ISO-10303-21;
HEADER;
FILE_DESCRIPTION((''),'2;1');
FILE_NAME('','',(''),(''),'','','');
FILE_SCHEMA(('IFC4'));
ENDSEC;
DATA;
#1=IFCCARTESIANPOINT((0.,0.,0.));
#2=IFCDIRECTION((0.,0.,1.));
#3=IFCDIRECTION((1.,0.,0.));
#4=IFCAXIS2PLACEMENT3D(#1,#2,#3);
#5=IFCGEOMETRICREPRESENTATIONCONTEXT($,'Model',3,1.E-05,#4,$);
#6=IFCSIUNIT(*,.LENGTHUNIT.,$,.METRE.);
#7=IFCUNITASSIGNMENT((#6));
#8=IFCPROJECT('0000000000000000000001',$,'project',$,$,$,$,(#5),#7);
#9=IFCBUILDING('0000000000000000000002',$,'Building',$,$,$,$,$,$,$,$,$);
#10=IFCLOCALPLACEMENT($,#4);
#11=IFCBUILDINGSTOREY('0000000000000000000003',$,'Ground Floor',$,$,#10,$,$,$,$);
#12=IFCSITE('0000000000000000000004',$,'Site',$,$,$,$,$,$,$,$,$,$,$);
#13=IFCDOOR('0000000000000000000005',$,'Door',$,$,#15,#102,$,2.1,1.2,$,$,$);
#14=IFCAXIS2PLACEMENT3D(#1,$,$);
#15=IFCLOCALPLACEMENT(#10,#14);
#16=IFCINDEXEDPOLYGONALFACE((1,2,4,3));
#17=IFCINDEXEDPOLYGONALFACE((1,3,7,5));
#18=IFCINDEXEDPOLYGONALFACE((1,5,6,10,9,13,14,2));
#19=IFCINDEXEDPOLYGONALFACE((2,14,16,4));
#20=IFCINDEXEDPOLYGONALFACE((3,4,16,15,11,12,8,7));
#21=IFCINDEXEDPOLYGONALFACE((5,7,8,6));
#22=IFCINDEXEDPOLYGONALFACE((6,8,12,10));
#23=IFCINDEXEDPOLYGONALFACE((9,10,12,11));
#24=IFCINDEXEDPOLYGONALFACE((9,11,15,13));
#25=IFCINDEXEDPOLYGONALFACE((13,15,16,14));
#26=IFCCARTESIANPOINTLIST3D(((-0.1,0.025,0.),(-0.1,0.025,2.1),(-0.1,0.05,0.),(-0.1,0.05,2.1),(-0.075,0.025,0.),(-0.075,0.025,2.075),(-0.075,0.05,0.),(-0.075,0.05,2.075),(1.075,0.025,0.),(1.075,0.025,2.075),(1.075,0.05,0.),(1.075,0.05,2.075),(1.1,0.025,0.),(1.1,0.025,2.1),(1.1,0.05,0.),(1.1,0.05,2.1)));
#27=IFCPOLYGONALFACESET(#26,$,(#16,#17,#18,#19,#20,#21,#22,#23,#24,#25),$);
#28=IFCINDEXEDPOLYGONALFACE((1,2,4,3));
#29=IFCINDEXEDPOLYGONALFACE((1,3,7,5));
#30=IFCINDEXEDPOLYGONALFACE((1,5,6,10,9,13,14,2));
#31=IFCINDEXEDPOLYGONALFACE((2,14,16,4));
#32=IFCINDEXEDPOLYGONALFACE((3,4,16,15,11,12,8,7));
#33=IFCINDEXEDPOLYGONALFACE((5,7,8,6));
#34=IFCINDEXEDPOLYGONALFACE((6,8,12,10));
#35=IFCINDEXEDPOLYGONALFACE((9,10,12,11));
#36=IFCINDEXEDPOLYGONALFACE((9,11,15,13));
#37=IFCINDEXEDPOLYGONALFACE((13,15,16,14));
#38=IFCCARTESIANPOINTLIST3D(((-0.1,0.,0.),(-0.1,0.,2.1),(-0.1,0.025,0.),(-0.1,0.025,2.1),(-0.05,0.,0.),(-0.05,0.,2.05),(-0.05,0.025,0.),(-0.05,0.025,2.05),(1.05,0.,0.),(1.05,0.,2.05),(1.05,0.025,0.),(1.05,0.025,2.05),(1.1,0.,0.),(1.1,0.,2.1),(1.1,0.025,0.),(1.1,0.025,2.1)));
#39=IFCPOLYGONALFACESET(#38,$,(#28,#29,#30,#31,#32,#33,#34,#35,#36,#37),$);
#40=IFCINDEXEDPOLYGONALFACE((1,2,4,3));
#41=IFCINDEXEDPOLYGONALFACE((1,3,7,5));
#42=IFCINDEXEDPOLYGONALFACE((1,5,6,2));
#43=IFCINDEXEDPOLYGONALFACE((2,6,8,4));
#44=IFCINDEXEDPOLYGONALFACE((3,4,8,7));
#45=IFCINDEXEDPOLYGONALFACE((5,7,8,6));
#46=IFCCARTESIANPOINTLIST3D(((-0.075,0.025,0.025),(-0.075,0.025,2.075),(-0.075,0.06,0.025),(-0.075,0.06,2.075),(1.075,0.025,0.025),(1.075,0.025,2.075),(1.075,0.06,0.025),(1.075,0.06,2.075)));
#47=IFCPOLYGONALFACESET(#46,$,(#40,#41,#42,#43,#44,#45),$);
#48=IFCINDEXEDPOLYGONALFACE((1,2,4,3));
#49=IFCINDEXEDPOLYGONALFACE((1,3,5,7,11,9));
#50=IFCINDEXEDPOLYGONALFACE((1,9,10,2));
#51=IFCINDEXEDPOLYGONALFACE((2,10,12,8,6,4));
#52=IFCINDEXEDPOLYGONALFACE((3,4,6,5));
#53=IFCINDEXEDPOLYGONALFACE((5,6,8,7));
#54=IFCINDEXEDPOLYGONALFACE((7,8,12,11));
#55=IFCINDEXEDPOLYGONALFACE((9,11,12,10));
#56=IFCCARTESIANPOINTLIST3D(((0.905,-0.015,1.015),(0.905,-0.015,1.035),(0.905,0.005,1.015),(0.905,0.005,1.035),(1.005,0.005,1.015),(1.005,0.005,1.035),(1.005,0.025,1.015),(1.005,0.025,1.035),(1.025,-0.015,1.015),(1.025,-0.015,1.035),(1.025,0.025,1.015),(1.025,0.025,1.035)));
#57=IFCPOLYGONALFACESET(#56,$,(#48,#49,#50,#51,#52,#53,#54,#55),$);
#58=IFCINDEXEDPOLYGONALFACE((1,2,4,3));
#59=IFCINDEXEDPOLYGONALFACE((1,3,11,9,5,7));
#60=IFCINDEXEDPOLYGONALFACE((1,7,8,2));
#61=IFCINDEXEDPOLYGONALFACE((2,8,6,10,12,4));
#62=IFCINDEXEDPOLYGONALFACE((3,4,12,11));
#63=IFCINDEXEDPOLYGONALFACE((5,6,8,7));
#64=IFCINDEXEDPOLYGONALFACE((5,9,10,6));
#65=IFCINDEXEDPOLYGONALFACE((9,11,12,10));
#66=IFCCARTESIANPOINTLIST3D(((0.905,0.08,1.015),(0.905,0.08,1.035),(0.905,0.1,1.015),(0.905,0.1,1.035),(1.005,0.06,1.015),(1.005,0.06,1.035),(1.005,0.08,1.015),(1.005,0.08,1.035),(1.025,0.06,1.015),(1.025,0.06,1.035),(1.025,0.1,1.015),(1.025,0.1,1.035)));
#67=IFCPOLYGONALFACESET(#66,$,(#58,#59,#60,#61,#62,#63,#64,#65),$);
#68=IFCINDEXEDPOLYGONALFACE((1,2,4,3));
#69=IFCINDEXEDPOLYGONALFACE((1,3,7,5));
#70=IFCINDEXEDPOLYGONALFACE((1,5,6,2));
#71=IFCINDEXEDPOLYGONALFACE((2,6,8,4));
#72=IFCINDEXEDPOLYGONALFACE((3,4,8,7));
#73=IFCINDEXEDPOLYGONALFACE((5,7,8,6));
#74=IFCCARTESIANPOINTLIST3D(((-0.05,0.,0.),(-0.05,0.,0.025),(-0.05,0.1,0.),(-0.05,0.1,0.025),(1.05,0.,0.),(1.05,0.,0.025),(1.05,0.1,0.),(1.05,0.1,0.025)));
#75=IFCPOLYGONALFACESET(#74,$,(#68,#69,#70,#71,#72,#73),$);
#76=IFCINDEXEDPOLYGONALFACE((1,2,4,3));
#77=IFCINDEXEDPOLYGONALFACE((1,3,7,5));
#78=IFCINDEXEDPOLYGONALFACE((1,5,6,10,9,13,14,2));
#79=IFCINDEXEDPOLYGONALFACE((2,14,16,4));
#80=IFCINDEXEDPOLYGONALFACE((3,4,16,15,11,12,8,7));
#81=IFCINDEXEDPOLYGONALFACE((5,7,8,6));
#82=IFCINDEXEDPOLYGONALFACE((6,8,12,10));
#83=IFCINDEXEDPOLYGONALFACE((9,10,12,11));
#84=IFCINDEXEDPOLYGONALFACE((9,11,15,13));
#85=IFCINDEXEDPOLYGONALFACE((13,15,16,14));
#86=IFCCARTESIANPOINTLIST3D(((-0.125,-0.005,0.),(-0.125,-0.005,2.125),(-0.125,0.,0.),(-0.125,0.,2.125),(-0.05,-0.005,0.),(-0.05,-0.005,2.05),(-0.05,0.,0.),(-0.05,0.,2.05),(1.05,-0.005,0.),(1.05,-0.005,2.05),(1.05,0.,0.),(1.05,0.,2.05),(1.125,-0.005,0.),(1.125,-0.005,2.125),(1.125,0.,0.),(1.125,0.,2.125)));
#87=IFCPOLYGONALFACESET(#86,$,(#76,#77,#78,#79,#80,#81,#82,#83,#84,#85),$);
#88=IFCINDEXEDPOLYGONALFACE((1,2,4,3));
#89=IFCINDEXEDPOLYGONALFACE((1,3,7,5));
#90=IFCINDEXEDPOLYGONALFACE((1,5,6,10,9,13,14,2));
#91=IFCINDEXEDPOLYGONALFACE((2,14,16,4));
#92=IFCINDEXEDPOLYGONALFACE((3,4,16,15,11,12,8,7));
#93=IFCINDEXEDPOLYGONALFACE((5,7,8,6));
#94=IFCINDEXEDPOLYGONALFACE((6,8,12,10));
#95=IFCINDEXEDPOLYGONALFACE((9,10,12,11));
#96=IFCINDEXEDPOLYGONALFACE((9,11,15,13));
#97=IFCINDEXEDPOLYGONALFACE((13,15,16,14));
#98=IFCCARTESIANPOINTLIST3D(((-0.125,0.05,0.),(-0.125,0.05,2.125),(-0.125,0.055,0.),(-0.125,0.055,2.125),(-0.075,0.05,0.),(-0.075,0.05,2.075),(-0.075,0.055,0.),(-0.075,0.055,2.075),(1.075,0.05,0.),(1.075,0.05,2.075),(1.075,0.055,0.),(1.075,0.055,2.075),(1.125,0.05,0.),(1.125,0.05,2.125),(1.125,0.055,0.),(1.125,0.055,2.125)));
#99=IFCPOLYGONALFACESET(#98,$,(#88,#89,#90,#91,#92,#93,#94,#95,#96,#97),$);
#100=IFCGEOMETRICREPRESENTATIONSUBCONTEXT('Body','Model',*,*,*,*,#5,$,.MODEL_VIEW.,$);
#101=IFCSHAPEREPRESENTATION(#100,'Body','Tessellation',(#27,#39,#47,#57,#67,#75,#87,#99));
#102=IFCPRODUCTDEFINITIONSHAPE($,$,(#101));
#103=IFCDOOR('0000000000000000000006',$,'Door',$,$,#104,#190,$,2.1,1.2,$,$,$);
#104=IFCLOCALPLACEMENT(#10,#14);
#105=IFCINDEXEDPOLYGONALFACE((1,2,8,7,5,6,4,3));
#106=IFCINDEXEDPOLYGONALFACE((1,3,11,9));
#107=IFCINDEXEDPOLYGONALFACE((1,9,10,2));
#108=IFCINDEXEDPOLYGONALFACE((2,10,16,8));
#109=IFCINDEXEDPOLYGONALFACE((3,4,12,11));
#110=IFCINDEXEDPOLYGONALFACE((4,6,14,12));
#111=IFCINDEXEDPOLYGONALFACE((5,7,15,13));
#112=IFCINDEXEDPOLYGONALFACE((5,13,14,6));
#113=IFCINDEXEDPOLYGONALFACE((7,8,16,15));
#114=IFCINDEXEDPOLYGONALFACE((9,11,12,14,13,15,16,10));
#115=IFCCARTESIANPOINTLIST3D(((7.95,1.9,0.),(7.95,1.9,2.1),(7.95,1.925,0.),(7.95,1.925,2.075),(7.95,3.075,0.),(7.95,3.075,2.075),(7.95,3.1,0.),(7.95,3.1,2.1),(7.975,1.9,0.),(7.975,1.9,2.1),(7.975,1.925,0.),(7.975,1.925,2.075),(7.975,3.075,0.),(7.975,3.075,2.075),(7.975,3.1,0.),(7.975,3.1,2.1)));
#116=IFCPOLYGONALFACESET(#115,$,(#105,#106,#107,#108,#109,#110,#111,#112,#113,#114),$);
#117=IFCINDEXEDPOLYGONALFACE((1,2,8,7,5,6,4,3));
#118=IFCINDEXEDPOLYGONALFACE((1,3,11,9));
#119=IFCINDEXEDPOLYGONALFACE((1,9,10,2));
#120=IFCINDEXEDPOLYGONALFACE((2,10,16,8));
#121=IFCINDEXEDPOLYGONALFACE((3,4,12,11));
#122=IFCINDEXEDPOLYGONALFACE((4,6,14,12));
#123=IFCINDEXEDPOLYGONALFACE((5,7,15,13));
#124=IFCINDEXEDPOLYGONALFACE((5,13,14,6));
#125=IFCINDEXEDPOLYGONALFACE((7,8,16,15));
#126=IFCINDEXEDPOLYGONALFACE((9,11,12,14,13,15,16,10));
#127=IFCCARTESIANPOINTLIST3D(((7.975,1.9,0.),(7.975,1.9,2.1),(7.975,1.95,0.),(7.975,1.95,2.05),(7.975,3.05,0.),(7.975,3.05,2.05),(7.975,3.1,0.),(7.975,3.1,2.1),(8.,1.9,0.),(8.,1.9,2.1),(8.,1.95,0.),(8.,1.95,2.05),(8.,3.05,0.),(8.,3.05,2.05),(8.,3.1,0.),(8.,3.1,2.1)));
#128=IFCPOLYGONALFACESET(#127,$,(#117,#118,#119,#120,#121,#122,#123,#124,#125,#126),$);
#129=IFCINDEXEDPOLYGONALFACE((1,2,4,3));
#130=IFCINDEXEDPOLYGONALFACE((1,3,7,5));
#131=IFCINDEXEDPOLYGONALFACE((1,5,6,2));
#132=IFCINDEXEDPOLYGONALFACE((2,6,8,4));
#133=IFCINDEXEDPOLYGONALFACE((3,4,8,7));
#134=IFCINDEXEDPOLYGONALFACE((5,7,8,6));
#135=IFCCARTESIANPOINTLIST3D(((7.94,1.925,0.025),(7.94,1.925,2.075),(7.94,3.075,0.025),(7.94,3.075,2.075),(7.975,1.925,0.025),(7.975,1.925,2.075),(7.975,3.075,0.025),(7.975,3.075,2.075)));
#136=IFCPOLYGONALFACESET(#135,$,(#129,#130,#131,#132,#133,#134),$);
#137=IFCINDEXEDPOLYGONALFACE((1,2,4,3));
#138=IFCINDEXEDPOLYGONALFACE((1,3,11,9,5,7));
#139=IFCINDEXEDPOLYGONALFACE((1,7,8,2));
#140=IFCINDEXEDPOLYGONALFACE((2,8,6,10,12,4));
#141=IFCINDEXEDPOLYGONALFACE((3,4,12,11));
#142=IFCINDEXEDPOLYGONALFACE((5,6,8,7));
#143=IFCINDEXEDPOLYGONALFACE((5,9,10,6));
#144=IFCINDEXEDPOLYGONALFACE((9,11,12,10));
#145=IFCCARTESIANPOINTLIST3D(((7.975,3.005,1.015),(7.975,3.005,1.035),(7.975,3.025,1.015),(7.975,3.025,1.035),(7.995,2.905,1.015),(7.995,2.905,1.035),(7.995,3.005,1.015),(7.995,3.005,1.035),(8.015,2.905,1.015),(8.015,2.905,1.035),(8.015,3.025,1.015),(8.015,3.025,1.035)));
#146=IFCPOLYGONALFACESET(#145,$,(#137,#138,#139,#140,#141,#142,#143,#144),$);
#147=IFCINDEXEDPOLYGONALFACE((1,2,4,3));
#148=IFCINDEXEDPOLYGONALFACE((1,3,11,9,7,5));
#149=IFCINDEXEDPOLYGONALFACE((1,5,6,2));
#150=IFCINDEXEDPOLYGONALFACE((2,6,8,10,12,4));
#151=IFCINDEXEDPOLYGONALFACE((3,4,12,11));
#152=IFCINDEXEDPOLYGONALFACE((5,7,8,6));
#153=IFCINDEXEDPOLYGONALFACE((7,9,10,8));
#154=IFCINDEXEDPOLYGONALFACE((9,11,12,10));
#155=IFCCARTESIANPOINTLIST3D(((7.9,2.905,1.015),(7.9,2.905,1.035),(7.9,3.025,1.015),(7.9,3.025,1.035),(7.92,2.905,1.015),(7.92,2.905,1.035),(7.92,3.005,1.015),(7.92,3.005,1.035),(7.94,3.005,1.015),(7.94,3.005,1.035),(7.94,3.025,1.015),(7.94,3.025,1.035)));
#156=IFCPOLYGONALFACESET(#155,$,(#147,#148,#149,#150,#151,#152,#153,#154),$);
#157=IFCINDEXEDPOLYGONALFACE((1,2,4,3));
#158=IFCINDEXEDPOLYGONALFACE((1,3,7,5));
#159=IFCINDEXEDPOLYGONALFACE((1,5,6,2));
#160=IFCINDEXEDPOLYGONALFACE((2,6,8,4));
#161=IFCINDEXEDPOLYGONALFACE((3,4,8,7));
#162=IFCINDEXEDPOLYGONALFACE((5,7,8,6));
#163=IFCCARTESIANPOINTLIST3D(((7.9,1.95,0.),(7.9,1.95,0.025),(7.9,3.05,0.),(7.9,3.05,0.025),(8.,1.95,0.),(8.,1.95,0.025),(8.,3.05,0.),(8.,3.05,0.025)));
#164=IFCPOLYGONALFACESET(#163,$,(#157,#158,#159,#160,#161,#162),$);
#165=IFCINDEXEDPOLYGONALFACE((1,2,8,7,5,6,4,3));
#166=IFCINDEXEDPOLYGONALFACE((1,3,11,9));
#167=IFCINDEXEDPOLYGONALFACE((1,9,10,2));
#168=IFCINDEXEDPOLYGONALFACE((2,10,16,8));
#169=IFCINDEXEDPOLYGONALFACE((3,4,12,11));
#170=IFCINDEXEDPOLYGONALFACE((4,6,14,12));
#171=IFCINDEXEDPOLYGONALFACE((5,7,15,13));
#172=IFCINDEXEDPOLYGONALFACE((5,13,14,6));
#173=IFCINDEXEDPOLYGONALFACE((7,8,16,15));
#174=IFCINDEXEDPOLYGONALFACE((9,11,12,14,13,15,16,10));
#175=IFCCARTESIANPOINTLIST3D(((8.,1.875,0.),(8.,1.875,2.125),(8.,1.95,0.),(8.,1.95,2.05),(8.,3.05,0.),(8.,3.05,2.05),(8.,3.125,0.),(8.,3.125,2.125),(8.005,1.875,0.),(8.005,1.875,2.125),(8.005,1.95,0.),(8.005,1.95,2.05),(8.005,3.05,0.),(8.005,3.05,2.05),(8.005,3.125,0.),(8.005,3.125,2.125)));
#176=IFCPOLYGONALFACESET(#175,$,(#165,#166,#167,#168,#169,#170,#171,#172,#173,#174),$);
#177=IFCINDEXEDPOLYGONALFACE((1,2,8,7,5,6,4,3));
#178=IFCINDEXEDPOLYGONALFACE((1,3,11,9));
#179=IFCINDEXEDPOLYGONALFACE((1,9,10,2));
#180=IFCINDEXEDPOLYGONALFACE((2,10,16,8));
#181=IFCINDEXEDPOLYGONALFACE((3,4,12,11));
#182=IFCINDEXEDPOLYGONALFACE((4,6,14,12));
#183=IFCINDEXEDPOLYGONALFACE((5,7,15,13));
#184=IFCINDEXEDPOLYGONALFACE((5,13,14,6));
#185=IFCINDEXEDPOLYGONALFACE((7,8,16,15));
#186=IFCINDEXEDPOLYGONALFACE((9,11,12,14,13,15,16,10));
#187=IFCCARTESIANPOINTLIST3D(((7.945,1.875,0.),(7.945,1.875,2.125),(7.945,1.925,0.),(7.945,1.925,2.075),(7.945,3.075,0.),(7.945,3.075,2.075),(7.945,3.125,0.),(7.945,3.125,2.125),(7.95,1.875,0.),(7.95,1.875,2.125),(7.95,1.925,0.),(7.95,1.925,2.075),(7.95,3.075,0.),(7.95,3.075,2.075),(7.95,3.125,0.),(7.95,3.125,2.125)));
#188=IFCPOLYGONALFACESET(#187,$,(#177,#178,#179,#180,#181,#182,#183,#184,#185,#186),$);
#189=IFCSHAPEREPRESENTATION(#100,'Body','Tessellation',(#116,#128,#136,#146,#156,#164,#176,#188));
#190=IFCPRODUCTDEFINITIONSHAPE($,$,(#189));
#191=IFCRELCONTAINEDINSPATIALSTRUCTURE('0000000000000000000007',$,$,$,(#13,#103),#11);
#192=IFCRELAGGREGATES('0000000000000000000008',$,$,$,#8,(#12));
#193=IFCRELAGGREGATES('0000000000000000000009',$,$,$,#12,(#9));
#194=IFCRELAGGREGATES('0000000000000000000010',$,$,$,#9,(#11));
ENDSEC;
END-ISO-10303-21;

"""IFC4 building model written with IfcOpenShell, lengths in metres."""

from ifc_helpers import new_model, si_unit, frame, origin_with_axes, place, context, subcontext, project, spatial, line, indexed_curve, outline, extrude, element, save


model = new_model("IFC4")

# Units and contexts
model_context = context("Model", 3, precision=1e-05, world=origin_with_axes())
body_context = subcontext(model_context, "Body", "Model", "MODEL_VIEW")
ifc_project = project(units=[si_unit("LENGTHUNIT", "METRE")], contexts=[model_context])

# Site, building, storey
site = spatial("IfcSite", under=ifc_project, Name="Site")
building = spatial("IfcBuilding", under=site, Name="Building")
storey_placement = place(None, origin_with_axes())
storey = spatial("IfcBuildingStorey", under=building, at=storey_placement, Name="Ground Floor")

# Doors
door_1_placement = place(storey_placement, frame((-0.1, 0.0, 0.0), z_axis=(0.0, 0.0, 1.0), x_axis=(1.0, 0.0, 0.0)))
element("IfcDoor", 1, at=door_1_placement, inside=storey, Name="Door", OverallHeight=2.1, OverallWidth=1.2, context=body_context, shape_type="SweptSolid", body=[
    extrude(outline(indexed_curve([(0.0, 0.0), (0.0, 2.1), (1.2, 2.1), (1.2, 0.0), (1.175, 0.0), (1.175, 2.075), (0.025, 2.075), (0.025, 0.0)], segments=[line(1, 2, 3, 4, 5, 6, 7, 8, 1)])), frame((0.0, 0.025, 0.0), z_axis=(0.0, -1.0, 0.0), x_axis=(1.0, 0.0, 0.0)), (0.0, 0.0, -1.0), 0.025),
    extrude(outline(indexed_curve([(0.0, 0.0), (0.0, 2.1), (1.2, 2.1), (1.2, 0.0), (1.15, 0.0), (1.15, 2.05), (0.05, 2.05), (0.05, 0.0)], segments=[line(1, 2, 3, 4, 5, 6, 7, 8, 1)])), frame((0.0, 0.0, 0.0), z_axis=(0.0, -1.0, 0.0), x_axis=(1.0, 0.0, 0.0)), (0.0, 0.0, -1.0), 0.025),
    extrude(outline(indexed_curve([(0.0, 0.0), (1.15, 0.0), (1.15, 0.035), (0.0, 0.035)], segments=[line(1, 2, 3, 4, 1)])), frame((0.025, 0.025, 0.025), z_axis=(0.0, 0.0, 1.0), x_axis=(1.0, 0.0, 0.0)), (0.0, 0.0, 1.0), 2.05),
    extrude(outline(indexed_curve([(0.0, 0.0), (0.0, -0.04), (-0.12, -0.04), (-0.12, -0.02), (-0.02, -0.02), (-0.02, 0.0)], segments=[line(1, 2, 3, 4, 5, 6, 1)])), frame((1.125, 0.025, 1.015), z_axis=(0.0, 0.0, 1.0), x_axis=(1.0, 0.0, 0.0)), (0.0, 0.0, 1.0), 0.02),
    extrude(outline(indexed_curve([(0.0, 0.0), (0.0, 0.04), (-0.12, 0.04), (-0.12, 0.02), (-0.02, 0.02), (-0.02, 0.0)], segments=[line(1, 2, 3, 4, 5, 6, 1)])), frame((1.125, 0.06, 1.015), z_axis=(0.0, 0.0, 1.0), x_axis=(1.0, 0.0, 0.0)), (0.0, 0.0, 1.0), 0.02),
    extrude(outline(indexed_curve([(0.0, 0.0), (1.1, 0.0), (1.1, 0.1), (0.0, 0.1)], segments=[line(1, 2, 3, 4, 1)])), frame((0.05, 0.0, 0.0), z_axis=(0.0, 0.0, 1.0), x_axis=(1.0, 0.0, 0.0)), (0.0, 0.0, 1.0), 0.025),
    extrude(outline(indexed_curve([(0.0, 0.0), (0.0, 2.125), (1.25, 2.125), (1.25, 0.0), (1.175, 0.0), (1.175, 2.05), (0.075, 2.05), (0.075, 0.0)], segments=[line(1, 2, 3, 4, 5, 6, 7, 8, 1)])), frame((-0.025, -0.005, 0.0), z_axis=(0.0, -1.0, 0.0), x_axis=(1.0, 0.0, 0.0)), (0.0, 0.0, -1.0), 0.005),
    extrude(outline(indexed_curve([(0.0, 0.0), (0.0, 2.125), (1.25, 2.125), (1.25, 0.0), (1.2, 0.0), (1.2, 2.075), (0.05, 2.075), (0.05, 0.0)], segments=[line(1, 2, 3, 4, 5, 6, 7, 8, 1)])), frame((-0.025, 0.05, 0.0), z_axis=(0.0, -1.0, 0.0), x_axis=(1.0, 0.0, 0.0)), (0.0, 0.0, -1.0), 0.005),
])
door_2_placement = place(storey_placement, frame((8.0, 1.9, 0.0), z_axis=(0.0, 0.0, 1.0), x_axis=(0.0, 1.0, 0.0)))
element("IfcDoor", 2, at=door_2_placement, inside=storey, Name="Door", OverallHeight=2.1, OverallWidth=1.2, context=body_context, shape_type="SweptSolid", body=[
    extrude(outline(indexed_curve([(0.0, 0.0), (0.0, 2.1), (1.2, 2.1), (1.2, 0.0), (1.175, 0.0), (1.175, 2.075), (0.025, 2.075), (0.025, 0.0)], segments=[line(1, 2, 3, 4, 5, 6, 7, 8, 1)])), frame((0.0, 0.025, 0.0), z_axis=(0.0, -1.0, 0.0), x_axis=(1.0, 0.0, 0.0)), (0.0, 0.0, -1.0), 0.025),
    extrude(outline(indexed_curve([(0.0, 0.0), (0.0, 2.1), (1.2, 2.1), (1.2, 0.0), (1.15, 0.0), (1.15, 2.05), (0.05, 2.05), (0.05, 0.0)], segments=[line(1, 2, 3, 4, 5, 6, 7, 8, 1)])), frame((0.0, 0.0, 0.0), z_axis=(0.0, -1.0, 0.0), x_axis=(1.0, 0.0, 0.0)), (0.0, 0.0, -1.0), 0.025),
    extrude(outline(indexed_curve([(0.0, 0.0), (1.15, 0.0), (1.15, 0.035), (0.0, 0.035)], segments=[line(1, 2, 3, 4, 1)])), frame((0.025, 0.025, 0.025), z_axis=(0.0, 0.0, 1.0), x_axis=(1.0, 0.0, 0.0)), (0.0, 0.0, 1.0), 2.05),
    extrude(outline(indexed_curve([(0.0, 0.0), (0.0, -0.04), (-0.12, -0.04), (-0.12, -0.02), (-0.02, -0.02), (-0.02, 0.0)], segments=[line(1, 2, 3, 4, 5, 6, 1)])), frame((1.125, 0.025, 1.015), z_axis=(0.0, 0.0, 1.0), x_axis=(1.0, 0.0, 0.0)), (0.0, 0.0, 1.0), 0.02),
    extrude(outline(indexed_curve([(0.0, 0.0), (0.0, 0.04), (-0.12, 0.04), (-0.12, 0.02), (-0.02, 0.02), (-0.02, 0.0)], segments=[line(1, 2, 3, 4, 5, 6, 1)])), frame((1.125, 0.06, 1.015), z_axis=(0.0, 0.0, 1.0), x_axis=(1.0, 0.0, 0.0)), (0.0, 0.0, 1.0), 0.02),
    extrude(outline(indexed_curve([(0.0, 0.0), (1.1, 0.0), (1.1, 0.1), (0.0, 0.1)], segments=[line(1, 2, 3, 4, 1)])), frame((0.05, 0.0, 0.0), z_axis=(0.0, 0.0, 1.0), x_axis=(1.0, 0.0, 0.0)), (0.0, 0.0, 1.0), 0.025),
    extrude(outline(indexed_curve([(0.0, 0.0), (0.0, 2.125), (1.25, 2.125), (1.25, 0.0), (1.175, 0.0), (1.175, 2.05), (0.075, 2.05), (0.075, 0.0)], segments=[line(1, 2, 3, 4, 5, 6, 7, 8, 1)])), frame((-0.025, -0.005, 0.0), z_axis=(0.0, -1.0, 0.0), x_axis=(1.0, 0.0, 0.0)), (0.0, 0.0, -1.0), 0.005),
    extrude(outline(indexed_curve([(0.0, 0.0), (0.0, 2.125), (1.25, 2.125), (1.25, 0.0), (1.2, 0.0), (1.2, 2.075), (0.05, 2.075), (0.05, 0.0)], segments=[line(1, 2, 3, 4, 5, 6, 7, 8, 1)])), frame((-0.025, 0.05, 0.0), z_axis=(0.0, -1.0, 0.0), x_axis=(1.0, 0.0, 0.0)), (0.0, 0.0, -1.0), 0.005),
])

save(model, "model.ifc")
